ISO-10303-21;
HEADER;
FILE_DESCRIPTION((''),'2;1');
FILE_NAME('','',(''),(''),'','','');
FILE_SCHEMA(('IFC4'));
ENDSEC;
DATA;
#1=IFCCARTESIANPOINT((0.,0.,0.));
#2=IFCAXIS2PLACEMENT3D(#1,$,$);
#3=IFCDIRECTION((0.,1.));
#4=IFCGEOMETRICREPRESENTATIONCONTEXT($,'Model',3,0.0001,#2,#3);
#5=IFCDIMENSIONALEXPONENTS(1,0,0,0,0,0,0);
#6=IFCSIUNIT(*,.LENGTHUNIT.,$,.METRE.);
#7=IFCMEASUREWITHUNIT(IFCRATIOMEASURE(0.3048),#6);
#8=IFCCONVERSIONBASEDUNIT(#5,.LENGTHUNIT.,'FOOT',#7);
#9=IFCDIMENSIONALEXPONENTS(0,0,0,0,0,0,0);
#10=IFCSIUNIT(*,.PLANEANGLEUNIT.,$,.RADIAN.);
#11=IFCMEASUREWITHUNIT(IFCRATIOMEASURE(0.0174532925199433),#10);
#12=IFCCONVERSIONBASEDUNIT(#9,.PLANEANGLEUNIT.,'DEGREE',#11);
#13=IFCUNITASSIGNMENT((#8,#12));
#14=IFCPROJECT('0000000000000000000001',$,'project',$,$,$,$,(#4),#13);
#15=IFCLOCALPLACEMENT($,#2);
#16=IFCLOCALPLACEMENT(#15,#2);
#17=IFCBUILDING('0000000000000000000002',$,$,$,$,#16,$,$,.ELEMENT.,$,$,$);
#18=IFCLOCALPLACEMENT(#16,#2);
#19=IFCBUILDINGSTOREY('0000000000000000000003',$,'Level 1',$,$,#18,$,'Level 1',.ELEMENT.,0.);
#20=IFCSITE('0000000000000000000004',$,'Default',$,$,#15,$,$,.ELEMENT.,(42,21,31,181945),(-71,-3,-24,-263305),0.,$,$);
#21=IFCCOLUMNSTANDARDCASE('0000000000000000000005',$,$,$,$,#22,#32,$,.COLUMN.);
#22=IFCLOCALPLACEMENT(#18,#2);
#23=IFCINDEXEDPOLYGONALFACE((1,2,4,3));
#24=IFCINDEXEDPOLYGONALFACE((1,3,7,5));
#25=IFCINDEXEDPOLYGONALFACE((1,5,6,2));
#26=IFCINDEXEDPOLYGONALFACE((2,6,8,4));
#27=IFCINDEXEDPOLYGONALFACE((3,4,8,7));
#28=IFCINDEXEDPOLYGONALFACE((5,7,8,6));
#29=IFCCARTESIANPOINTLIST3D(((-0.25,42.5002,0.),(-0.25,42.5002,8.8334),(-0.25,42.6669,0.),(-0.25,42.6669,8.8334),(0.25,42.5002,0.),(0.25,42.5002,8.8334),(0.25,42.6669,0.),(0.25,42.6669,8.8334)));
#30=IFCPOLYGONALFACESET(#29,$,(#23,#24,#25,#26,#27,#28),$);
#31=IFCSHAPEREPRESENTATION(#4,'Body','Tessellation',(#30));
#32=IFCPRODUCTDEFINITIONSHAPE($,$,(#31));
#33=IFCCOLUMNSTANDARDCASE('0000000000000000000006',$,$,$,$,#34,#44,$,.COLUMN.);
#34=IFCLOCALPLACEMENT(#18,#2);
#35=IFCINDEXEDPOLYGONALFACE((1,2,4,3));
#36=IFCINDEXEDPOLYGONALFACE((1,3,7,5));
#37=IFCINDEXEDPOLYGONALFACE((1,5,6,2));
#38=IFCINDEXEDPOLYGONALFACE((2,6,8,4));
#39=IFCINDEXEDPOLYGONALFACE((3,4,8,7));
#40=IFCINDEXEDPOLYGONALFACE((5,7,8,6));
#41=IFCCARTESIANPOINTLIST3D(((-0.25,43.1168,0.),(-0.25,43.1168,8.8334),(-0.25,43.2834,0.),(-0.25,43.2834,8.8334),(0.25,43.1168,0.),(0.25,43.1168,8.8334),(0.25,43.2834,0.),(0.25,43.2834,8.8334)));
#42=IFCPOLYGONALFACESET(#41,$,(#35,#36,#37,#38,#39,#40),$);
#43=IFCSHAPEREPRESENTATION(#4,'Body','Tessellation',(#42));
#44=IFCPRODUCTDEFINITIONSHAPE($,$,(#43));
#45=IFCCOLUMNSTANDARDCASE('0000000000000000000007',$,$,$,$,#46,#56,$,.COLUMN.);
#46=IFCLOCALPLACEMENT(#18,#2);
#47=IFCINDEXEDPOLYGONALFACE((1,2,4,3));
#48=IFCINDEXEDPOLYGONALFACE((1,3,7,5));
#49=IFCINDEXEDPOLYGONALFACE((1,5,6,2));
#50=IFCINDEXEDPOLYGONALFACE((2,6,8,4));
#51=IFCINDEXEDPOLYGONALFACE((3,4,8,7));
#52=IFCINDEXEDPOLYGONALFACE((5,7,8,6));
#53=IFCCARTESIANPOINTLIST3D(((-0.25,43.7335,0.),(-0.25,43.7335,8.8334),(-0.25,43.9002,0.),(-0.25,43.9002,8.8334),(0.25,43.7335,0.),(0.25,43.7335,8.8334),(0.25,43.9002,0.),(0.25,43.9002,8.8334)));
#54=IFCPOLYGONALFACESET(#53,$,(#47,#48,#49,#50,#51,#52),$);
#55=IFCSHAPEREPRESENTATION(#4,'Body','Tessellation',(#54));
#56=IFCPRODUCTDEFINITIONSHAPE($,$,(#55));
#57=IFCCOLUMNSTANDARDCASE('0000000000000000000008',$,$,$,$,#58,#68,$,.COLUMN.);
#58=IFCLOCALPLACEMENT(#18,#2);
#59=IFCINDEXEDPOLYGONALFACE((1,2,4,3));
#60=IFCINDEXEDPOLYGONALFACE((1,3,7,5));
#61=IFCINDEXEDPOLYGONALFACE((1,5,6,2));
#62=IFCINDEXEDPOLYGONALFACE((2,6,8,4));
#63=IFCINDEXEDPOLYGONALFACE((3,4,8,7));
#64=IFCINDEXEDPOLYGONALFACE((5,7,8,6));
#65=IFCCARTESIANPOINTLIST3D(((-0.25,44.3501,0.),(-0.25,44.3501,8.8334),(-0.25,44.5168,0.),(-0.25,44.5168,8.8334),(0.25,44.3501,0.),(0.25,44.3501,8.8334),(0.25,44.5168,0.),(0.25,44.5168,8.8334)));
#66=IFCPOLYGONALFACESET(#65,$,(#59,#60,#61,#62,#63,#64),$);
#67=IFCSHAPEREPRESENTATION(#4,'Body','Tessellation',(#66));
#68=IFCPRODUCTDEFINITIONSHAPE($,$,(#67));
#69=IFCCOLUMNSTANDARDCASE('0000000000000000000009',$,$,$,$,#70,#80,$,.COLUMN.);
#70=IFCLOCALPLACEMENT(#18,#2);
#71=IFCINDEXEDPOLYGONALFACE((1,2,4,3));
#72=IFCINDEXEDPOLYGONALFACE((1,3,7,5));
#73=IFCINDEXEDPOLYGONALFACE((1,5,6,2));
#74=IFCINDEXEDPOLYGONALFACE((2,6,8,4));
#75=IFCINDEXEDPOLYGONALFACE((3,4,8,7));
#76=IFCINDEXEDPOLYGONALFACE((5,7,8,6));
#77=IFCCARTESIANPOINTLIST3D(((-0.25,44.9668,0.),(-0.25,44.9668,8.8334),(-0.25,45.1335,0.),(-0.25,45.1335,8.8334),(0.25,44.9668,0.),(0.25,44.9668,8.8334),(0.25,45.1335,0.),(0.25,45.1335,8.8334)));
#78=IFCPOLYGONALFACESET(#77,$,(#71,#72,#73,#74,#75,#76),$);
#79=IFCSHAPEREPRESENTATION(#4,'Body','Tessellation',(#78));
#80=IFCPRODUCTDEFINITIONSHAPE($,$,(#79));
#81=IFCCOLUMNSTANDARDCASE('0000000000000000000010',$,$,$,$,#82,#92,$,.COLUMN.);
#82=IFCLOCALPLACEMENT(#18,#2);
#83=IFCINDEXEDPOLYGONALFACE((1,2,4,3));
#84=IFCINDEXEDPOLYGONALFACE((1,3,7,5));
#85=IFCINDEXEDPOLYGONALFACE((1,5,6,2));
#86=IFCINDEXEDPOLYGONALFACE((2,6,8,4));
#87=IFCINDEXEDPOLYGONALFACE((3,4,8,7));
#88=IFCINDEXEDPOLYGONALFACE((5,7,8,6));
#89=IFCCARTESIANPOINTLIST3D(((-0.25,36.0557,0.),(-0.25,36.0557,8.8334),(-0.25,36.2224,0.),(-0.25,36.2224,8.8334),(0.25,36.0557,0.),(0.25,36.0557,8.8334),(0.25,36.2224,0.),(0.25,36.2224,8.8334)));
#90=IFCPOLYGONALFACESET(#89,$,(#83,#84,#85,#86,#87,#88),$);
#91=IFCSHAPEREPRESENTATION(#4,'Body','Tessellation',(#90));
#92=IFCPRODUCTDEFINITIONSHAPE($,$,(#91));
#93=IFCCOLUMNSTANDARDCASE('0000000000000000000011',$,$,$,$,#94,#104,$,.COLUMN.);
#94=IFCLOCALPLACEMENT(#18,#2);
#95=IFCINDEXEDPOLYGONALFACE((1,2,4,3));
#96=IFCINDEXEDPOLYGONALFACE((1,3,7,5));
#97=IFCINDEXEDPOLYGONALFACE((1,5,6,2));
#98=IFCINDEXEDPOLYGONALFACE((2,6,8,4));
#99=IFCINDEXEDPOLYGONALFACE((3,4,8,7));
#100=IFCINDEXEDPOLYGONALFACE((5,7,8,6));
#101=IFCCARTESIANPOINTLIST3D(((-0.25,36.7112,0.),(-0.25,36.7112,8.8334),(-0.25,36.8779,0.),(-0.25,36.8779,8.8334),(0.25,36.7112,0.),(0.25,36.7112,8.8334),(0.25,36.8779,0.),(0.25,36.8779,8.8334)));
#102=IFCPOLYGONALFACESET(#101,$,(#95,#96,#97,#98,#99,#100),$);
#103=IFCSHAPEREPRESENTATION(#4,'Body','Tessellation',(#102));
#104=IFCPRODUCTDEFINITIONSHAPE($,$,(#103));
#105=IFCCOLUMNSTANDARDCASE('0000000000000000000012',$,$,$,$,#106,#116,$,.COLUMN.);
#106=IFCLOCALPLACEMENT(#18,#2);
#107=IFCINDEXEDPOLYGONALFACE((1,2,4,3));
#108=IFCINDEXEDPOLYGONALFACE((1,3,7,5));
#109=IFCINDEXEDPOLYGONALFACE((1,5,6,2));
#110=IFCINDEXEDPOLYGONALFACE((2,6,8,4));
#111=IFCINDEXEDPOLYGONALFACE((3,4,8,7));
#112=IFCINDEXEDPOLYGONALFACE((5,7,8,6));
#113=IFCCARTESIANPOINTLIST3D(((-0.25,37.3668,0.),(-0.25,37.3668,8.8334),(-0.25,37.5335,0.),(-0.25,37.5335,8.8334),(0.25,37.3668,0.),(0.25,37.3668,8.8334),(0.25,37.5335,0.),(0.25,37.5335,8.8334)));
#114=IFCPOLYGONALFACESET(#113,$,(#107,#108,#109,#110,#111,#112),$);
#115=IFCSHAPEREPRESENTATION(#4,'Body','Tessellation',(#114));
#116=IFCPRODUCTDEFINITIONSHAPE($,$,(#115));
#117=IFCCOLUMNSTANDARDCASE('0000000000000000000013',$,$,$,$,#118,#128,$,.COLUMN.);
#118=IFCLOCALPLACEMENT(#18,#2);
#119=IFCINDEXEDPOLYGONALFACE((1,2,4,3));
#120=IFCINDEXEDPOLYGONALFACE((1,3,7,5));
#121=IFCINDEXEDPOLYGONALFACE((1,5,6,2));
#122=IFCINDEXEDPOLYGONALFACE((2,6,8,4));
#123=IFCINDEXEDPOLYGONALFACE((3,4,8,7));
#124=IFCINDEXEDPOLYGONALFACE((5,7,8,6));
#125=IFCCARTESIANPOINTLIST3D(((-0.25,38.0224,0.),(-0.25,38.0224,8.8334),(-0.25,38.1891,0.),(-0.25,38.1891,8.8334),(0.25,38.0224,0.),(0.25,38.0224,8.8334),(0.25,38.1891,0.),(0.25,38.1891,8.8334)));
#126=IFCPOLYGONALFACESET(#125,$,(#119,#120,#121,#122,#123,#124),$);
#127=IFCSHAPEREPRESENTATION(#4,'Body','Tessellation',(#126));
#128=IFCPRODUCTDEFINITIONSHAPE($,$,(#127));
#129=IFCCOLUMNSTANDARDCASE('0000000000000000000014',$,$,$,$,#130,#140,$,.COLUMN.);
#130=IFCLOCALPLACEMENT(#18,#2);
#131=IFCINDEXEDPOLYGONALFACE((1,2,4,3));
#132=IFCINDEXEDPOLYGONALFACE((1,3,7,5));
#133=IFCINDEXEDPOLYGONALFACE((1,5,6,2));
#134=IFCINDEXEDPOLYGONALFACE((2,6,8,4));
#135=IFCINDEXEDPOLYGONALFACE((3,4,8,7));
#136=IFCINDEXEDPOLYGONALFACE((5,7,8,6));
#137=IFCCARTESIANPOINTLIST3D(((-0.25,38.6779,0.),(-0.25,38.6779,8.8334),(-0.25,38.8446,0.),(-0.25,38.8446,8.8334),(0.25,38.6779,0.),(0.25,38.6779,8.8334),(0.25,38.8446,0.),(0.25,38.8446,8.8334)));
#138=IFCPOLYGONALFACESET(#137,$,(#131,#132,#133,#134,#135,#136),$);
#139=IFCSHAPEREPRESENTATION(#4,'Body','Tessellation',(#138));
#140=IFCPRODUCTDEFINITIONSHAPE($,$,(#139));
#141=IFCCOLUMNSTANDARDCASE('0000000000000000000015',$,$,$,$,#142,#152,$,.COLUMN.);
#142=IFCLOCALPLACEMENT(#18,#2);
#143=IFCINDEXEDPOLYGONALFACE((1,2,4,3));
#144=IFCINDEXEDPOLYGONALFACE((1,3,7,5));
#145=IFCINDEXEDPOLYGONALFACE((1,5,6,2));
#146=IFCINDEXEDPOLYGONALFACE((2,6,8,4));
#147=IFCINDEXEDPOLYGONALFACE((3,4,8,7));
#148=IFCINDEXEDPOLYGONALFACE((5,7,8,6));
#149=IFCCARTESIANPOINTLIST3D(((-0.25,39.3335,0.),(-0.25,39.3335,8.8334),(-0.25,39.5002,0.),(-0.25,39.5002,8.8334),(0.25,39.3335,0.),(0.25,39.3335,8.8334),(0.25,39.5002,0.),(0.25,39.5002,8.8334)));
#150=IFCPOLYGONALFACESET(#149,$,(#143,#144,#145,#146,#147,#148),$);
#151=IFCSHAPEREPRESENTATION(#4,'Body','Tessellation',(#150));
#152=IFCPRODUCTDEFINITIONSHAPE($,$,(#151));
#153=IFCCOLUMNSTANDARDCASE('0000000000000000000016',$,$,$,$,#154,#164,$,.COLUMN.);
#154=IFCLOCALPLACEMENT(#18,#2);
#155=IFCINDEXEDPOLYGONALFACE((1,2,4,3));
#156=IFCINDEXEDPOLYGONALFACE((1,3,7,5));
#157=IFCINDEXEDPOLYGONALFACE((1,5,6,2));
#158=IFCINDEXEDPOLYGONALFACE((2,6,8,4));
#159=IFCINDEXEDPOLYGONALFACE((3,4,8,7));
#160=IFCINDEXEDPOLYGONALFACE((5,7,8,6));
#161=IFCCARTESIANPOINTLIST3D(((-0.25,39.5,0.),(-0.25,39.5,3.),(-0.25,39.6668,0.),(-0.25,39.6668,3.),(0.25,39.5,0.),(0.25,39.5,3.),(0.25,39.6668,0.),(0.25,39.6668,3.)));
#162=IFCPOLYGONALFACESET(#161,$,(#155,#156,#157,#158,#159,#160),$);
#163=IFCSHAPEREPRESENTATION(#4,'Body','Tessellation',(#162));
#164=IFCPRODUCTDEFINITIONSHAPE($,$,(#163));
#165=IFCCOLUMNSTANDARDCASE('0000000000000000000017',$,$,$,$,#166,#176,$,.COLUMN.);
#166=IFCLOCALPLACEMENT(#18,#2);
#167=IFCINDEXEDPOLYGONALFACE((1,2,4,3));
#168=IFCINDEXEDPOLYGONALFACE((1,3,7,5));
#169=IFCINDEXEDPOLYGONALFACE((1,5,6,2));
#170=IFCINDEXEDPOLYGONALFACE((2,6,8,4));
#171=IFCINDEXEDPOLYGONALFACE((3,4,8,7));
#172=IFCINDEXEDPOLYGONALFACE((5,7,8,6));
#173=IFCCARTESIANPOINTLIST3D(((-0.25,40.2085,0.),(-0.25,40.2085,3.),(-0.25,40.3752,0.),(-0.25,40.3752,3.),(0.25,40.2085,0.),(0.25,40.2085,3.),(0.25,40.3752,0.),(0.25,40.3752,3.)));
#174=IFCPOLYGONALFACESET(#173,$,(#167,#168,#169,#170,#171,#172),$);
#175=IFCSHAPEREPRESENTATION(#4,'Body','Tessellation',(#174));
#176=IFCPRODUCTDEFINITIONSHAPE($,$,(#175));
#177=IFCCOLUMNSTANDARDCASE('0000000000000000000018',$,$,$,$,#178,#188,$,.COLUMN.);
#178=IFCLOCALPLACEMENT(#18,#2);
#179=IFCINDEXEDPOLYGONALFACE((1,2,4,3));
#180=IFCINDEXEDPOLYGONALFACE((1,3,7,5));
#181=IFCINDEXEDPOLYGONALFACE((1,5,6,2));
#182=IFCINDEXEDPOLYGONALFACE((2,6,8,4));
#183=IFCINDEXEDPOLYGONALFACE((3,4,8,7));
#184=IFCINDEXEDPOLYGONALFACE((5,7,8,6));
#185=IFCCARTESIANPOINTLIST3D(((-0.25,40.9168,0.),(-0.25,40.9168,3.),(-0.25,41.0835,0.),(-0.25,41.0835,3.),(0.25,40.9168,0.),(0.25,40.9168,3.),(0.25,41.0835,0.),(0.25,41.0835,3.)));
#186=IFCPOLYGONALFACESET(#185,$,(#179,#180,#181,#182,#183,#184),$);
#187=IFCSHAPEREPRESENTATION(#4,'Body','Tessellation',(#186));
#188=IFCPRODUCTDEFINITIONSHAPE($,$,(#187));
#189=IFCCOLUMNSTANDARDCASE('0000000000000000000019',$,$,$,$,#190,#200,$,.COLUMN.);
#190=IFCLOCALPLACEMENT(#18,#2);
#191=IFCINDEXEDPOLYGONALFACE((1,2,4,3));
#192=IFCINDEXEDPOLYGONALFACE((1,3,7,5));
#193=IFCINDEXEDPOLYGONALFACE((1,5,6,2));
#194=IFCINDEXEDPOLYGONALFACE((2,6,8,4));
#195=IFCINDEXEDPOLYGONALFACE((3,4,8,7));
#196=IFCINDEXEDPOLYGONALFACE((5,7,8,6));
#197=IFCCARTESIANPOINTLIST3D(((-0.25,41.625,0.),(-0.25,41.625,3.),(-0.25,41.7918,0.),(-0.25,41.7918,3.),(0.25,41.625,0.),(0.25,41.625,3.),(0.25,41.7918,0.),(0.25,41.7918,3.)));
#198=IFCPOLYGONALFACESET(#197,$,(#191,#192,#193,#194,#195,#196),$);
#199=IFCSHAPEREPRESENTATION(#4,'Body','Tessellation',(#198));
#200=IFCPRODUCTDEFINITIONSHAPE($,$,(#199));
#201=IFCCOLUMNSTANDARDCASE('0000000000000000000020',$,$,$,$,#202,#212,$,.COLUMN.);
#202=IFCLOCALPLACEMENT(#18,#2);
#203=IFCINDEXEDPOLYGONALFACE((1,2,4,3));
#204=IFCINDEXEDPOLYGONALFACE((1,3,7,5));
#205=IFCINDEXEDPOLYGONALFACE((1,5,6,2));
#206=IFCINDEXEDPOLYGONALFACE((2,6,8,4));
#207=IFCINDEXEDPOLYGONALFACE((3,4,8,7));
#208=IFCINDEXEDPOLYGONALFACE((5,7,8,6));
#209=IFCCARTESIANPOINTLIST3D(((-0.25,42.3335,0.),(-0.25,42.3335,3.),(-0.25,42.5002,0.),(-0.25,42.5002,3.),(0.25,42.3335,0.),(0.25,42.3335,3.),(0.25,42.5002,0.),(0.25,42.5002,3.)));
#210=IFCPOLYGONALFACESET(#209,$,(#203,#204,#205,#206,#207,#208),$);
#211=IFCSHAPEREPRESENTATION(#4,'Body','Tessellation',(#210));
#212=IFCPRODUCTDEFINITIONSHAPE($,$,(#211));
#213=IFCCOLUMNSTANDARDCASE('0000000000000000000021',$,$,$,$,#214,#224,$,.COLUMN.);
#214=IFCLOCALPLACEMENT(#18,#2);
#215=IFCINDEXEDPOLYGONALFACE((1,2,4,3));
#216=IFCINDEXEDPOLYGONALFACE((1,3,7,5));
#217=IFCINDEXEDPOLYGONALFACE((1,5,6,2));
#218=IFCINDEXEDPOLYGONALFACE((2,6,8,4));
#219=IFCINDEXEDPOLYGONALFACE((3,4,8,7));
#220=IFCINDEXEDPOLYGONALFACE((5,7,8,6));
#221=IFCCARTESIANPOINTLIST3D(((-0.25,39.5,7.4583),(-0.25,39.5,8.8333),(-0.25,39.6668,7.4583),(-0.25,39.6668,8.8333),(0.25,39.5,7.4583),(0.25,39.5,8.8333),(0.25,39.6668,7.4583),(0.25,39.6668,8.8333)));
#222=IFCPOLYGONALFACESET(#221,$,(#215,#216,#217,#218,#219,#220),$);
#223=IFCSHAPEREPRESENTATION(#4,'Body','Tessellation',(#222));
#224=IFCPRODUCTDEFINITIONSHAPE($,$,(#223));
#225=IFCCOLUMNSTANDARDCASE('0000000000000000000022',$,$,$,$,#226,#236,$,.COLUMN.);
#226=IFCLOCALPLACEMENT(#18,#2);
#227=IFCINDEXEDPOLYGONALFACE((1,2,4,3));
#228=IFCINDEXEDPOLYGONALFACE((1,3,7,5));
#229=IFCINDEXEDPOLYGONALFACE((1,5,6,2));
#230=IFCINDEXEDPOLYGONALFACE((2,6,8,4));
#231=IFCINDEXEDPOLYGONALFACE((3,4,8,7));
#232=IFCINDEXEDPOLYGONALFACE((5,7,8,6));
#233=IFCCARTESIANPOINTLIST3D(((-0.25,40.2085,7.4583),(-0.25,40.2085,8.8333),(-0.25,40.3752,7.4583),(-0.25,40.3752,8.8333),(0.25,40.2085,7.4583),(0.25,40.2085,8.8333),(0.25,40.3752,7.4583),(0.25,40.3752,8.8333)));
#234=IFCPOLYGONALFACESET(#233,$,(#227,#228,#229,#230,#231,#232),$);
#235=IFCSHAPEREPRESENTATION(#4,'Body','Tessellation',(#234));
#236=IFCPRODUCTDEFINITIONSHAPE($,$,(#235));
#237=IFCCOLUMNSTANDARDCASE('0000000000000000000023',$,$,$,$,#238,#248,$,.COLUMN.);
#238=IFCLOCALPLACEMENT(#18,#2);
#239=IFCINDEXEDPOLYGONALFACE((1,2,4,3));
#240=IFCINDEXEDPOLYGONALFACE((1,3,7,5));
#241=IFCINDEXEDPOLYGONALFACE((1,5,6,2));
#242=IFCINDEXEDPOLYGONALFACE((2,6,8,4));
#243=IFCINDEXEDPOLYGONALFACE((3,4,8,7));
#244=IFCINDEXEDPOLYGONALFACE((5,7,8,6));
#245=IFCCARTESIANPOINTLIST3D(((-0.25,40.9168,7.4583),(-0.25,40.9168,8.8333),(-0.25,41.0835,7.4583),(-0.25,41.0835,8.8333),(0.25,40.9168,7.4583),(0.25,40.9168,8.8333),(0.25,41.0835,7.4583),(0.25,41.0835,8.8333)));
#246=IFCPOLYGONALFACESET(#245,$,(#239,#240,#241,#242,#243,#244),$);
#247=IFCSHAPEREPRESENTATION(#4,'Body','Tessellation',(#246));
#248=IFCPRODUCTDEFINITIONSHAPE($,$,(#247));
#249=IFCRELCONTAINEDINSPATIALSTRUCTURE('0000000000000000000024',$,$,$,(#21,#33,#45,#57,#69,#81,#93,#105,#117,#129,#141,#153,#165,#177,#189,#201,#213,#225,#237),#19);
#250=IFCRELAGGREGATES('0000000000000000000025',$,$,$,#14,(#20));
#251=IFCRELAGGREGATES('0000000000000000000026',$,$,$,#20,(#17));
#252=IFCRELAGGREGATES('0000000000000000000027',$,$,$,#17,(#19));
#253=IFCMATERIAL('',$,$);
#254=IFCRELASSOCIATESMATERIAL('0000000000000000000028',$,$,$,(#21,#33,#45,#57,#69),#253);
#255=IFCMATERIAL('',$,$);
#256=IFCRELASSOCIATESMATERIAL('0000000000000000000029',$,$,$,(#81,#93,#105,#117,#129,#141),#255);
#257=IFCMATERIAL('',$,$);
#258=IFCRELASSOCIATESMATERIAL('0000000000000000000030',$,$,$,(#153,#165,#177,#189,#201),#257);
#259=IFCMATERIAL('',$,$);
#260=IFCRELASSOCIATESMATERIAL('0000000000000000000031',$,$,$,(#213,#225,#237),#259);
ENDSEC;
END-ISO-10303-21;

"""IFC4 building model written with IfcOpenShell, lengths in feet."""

from ifc_helpers import new_model, entity, si_unit, converted_unit, direction, frame, origin, place, context, project, spatial, rectangle, extrude, material, element, save


model = new_model("IFC4")

# Units and contexts
model_context = context("Model", 3, precision=0.0001, world=origin(), true_north=direction((0.0, 1.0)))
ifc_project = project(units=[converted_unit("LENGTHUNIT", "FOOT", entity("IfcRatioMeasure", 0.3048), si_unit("LENGTHUNIT", "METRE"), dimensions=[1, 0, 0, 0, 0, 0, 0]), converted_unit("PLANEANGLEUNIT", "DEGREE", entity("IfcRatioMeasure", 0.0174532925199433), si_unit("PLANEANGLEUNIT", "RADIAN"), dimensions=[0, 0, 0, 0, 0, 0, 0])], contexts=[model_context])

# Site, building, storey
site_placement = place(None, origin())
site = spatial("IfcSite", under=ifc_project, at=site_placement, Name="Default", CompositionType="ELEMENT", RefLatitude=(42, 21, 31, 181945), RefLongitude=(-71, -3, -24, -263305), RefElevation=0.0)
building_placement = place(site_placement, origin())
building = spatial("IfcBuilding", under=site, at=building_placement, CompositionType="ELEMENT")
storey_placement = place(building_placement, origin())
storey = spatial("IfcBuildingStorey", under=building, at=storey_placement, Name="Level 1", LongName="Level 1", CompositionType="ELEMENT", Elevation=0.0)

# Columns
ifc_material_1 = material(Name="")
placement_1 = place(storey_placement, frame((0.0, -0.25, 0.0), z_axis=(0.0, 0.0, 1.0), x_axis=(0.0, 1.0, 0.0)))
for number, where, z_axis, x_axis in (
    (1, (42.8335, 0.0, 0.0), (0.0, 0.0, 1.0), (1.0, 0.0, 0.0)),
    (2, (43.4501, 0.0, 0.0), (0.0, 0.0, 1.0), (1.0, 0.0, 0.0)),
    (3, (44.0668, 0.0, 0.0), (0.0, 0.0, 1.0), (1.0, 0.0, 0.0)),
    (4, (44.6834, 0.0, 0.0), (0.0, 0.0, 1.0), (1.0, 0.0, 0.0)),
    (5, (45.3001, 0.0, 0.0), (0.0, 0.0, 1.0), (1.0, 0.0, 0.0)),
):
    element("IfcColumnStandardCase", number, at=place(placement_1, frame(where, z_axis=z_axis, x_axis=x_axis)), inside=storey, material=ifc_material_1, PredefinedType="COLUMN", context=model_context, shape_type="SweptSolid", body=[
        extrude(rectangle(XDim=0.1667, YDim=0.5), origin(), (0.0, 0.0, 1.0), 8.8334),
    ])
ifc_material_2 = material(Name="")
for number, where, z_axis, x_axis in (
    (6, (36.389, 0.0, 0.0), (0.0, 0.0, 1.0), (1.0, 0.0, 0.0)),
    (7, (37.0445, 0.0, 0.0), (0.0, 0.0, 1.0), (1.0, 0.0, 0.0)),
    (8, (37.7001, 0.0, 0.0), (0.0, 0.0, 1.0), (1.0, 0.0, 0.0)),
    (9, (38.3557, 0.0, 0.0), (0.0, 0.0, 1.0), (1.0, 0.0, 0.0)),
    (10, (39.0112, 0.0, 0.0), (0.0, 0.0, 1.0), (1.0, 0.0, 0.0)),
    (11, (39.6668, 0.0, 0.0), (0.0, 0.0, 1.0), (1.0, 0.0, 0.0)),
):
    element("IfcColumnStandardCase", number, at=place(placement_1, frame(where, z_axis=z_axis, x_axis=x_axis)), inside=storey, material=ifc_material_2, PredefinedType="COLUMN", context=model_context, shape_type="SweptSolid", body=[
        extrude(rectangle(XDim=0.1667, YDim=0.5), origin(), (0.0, 0.0, 1.0), 8.8334),
    ])
ifc_material_3 = material(Name="")
for number, where, z_axis, x_axis in (
    (12, (39.8334, 0.0, 0.0), (0.0, 0.0, 1.0), (1.0, 0.0, 0.0)),
    (13, (40.5418, 0.0, 0.0), (0.0, 0.0, 1.0), (1.0, 0.0, 0.0)),
    (14, (41.2501, 0.0, 0.0), (0.0, 0.0, 1.0), (1.0, 0.0, 0.0)),
    (15, (41.9584, 0.0, 0.0), (0.0, 0.0, 1.0), (1.0, 0.0, 0.0)),
    (16, (42.6668, 0.0, 0.0), (0.0, 0.0, 1.0), (1.0, 0.0, 0.0)),
):
    element("IfcColumnStandardCase", number, at=place(placement_1, frame(where, z_axis=z_axis, x_axis=x_axis)), inside=storey, material=ifc_material_3, PredefinedType="COLUMN", context=model_context, shape_type="SweptSolid", body=[
        extrude(rectangle(XDim=0.1667, YDim=0.5), origin(), (0.0, 0.0, 1.0), 3.0),
    ])
ifc_material_4 = material(Name="")
for number, where, z_axis, x_axis in (
    (17, (39.8334, 0.0, 7.4583), (0.0, 0.0, 1.0), (1.0, 0.0, 0.0)),
    (18, (40.5418, 0.0, 7.4583), (0.0, 0.0, 1.0), (1.0, 0.0, 0.0)),
    (19, (41.2501, 0.0, 7.4583), (0.0, 0.0, 1.0), (1.0, 0.0, 0.0)),
):
    element("IfcColumnStandardCase", number, at=place(placement_1, frame(where, z_axis=z_axis, x_axis=x_axis)), inside=storey, material=ifc_material_4, PredefinedType="COLUMN", context=model_context, shape_type="SweptSolid", body=[
        extrude(rectangle(XDim=0.1667, YDim=0.5), origin(), (0.0, 0.0, 1.0), 1.375),
    ])

save(model, "model.ifc")
